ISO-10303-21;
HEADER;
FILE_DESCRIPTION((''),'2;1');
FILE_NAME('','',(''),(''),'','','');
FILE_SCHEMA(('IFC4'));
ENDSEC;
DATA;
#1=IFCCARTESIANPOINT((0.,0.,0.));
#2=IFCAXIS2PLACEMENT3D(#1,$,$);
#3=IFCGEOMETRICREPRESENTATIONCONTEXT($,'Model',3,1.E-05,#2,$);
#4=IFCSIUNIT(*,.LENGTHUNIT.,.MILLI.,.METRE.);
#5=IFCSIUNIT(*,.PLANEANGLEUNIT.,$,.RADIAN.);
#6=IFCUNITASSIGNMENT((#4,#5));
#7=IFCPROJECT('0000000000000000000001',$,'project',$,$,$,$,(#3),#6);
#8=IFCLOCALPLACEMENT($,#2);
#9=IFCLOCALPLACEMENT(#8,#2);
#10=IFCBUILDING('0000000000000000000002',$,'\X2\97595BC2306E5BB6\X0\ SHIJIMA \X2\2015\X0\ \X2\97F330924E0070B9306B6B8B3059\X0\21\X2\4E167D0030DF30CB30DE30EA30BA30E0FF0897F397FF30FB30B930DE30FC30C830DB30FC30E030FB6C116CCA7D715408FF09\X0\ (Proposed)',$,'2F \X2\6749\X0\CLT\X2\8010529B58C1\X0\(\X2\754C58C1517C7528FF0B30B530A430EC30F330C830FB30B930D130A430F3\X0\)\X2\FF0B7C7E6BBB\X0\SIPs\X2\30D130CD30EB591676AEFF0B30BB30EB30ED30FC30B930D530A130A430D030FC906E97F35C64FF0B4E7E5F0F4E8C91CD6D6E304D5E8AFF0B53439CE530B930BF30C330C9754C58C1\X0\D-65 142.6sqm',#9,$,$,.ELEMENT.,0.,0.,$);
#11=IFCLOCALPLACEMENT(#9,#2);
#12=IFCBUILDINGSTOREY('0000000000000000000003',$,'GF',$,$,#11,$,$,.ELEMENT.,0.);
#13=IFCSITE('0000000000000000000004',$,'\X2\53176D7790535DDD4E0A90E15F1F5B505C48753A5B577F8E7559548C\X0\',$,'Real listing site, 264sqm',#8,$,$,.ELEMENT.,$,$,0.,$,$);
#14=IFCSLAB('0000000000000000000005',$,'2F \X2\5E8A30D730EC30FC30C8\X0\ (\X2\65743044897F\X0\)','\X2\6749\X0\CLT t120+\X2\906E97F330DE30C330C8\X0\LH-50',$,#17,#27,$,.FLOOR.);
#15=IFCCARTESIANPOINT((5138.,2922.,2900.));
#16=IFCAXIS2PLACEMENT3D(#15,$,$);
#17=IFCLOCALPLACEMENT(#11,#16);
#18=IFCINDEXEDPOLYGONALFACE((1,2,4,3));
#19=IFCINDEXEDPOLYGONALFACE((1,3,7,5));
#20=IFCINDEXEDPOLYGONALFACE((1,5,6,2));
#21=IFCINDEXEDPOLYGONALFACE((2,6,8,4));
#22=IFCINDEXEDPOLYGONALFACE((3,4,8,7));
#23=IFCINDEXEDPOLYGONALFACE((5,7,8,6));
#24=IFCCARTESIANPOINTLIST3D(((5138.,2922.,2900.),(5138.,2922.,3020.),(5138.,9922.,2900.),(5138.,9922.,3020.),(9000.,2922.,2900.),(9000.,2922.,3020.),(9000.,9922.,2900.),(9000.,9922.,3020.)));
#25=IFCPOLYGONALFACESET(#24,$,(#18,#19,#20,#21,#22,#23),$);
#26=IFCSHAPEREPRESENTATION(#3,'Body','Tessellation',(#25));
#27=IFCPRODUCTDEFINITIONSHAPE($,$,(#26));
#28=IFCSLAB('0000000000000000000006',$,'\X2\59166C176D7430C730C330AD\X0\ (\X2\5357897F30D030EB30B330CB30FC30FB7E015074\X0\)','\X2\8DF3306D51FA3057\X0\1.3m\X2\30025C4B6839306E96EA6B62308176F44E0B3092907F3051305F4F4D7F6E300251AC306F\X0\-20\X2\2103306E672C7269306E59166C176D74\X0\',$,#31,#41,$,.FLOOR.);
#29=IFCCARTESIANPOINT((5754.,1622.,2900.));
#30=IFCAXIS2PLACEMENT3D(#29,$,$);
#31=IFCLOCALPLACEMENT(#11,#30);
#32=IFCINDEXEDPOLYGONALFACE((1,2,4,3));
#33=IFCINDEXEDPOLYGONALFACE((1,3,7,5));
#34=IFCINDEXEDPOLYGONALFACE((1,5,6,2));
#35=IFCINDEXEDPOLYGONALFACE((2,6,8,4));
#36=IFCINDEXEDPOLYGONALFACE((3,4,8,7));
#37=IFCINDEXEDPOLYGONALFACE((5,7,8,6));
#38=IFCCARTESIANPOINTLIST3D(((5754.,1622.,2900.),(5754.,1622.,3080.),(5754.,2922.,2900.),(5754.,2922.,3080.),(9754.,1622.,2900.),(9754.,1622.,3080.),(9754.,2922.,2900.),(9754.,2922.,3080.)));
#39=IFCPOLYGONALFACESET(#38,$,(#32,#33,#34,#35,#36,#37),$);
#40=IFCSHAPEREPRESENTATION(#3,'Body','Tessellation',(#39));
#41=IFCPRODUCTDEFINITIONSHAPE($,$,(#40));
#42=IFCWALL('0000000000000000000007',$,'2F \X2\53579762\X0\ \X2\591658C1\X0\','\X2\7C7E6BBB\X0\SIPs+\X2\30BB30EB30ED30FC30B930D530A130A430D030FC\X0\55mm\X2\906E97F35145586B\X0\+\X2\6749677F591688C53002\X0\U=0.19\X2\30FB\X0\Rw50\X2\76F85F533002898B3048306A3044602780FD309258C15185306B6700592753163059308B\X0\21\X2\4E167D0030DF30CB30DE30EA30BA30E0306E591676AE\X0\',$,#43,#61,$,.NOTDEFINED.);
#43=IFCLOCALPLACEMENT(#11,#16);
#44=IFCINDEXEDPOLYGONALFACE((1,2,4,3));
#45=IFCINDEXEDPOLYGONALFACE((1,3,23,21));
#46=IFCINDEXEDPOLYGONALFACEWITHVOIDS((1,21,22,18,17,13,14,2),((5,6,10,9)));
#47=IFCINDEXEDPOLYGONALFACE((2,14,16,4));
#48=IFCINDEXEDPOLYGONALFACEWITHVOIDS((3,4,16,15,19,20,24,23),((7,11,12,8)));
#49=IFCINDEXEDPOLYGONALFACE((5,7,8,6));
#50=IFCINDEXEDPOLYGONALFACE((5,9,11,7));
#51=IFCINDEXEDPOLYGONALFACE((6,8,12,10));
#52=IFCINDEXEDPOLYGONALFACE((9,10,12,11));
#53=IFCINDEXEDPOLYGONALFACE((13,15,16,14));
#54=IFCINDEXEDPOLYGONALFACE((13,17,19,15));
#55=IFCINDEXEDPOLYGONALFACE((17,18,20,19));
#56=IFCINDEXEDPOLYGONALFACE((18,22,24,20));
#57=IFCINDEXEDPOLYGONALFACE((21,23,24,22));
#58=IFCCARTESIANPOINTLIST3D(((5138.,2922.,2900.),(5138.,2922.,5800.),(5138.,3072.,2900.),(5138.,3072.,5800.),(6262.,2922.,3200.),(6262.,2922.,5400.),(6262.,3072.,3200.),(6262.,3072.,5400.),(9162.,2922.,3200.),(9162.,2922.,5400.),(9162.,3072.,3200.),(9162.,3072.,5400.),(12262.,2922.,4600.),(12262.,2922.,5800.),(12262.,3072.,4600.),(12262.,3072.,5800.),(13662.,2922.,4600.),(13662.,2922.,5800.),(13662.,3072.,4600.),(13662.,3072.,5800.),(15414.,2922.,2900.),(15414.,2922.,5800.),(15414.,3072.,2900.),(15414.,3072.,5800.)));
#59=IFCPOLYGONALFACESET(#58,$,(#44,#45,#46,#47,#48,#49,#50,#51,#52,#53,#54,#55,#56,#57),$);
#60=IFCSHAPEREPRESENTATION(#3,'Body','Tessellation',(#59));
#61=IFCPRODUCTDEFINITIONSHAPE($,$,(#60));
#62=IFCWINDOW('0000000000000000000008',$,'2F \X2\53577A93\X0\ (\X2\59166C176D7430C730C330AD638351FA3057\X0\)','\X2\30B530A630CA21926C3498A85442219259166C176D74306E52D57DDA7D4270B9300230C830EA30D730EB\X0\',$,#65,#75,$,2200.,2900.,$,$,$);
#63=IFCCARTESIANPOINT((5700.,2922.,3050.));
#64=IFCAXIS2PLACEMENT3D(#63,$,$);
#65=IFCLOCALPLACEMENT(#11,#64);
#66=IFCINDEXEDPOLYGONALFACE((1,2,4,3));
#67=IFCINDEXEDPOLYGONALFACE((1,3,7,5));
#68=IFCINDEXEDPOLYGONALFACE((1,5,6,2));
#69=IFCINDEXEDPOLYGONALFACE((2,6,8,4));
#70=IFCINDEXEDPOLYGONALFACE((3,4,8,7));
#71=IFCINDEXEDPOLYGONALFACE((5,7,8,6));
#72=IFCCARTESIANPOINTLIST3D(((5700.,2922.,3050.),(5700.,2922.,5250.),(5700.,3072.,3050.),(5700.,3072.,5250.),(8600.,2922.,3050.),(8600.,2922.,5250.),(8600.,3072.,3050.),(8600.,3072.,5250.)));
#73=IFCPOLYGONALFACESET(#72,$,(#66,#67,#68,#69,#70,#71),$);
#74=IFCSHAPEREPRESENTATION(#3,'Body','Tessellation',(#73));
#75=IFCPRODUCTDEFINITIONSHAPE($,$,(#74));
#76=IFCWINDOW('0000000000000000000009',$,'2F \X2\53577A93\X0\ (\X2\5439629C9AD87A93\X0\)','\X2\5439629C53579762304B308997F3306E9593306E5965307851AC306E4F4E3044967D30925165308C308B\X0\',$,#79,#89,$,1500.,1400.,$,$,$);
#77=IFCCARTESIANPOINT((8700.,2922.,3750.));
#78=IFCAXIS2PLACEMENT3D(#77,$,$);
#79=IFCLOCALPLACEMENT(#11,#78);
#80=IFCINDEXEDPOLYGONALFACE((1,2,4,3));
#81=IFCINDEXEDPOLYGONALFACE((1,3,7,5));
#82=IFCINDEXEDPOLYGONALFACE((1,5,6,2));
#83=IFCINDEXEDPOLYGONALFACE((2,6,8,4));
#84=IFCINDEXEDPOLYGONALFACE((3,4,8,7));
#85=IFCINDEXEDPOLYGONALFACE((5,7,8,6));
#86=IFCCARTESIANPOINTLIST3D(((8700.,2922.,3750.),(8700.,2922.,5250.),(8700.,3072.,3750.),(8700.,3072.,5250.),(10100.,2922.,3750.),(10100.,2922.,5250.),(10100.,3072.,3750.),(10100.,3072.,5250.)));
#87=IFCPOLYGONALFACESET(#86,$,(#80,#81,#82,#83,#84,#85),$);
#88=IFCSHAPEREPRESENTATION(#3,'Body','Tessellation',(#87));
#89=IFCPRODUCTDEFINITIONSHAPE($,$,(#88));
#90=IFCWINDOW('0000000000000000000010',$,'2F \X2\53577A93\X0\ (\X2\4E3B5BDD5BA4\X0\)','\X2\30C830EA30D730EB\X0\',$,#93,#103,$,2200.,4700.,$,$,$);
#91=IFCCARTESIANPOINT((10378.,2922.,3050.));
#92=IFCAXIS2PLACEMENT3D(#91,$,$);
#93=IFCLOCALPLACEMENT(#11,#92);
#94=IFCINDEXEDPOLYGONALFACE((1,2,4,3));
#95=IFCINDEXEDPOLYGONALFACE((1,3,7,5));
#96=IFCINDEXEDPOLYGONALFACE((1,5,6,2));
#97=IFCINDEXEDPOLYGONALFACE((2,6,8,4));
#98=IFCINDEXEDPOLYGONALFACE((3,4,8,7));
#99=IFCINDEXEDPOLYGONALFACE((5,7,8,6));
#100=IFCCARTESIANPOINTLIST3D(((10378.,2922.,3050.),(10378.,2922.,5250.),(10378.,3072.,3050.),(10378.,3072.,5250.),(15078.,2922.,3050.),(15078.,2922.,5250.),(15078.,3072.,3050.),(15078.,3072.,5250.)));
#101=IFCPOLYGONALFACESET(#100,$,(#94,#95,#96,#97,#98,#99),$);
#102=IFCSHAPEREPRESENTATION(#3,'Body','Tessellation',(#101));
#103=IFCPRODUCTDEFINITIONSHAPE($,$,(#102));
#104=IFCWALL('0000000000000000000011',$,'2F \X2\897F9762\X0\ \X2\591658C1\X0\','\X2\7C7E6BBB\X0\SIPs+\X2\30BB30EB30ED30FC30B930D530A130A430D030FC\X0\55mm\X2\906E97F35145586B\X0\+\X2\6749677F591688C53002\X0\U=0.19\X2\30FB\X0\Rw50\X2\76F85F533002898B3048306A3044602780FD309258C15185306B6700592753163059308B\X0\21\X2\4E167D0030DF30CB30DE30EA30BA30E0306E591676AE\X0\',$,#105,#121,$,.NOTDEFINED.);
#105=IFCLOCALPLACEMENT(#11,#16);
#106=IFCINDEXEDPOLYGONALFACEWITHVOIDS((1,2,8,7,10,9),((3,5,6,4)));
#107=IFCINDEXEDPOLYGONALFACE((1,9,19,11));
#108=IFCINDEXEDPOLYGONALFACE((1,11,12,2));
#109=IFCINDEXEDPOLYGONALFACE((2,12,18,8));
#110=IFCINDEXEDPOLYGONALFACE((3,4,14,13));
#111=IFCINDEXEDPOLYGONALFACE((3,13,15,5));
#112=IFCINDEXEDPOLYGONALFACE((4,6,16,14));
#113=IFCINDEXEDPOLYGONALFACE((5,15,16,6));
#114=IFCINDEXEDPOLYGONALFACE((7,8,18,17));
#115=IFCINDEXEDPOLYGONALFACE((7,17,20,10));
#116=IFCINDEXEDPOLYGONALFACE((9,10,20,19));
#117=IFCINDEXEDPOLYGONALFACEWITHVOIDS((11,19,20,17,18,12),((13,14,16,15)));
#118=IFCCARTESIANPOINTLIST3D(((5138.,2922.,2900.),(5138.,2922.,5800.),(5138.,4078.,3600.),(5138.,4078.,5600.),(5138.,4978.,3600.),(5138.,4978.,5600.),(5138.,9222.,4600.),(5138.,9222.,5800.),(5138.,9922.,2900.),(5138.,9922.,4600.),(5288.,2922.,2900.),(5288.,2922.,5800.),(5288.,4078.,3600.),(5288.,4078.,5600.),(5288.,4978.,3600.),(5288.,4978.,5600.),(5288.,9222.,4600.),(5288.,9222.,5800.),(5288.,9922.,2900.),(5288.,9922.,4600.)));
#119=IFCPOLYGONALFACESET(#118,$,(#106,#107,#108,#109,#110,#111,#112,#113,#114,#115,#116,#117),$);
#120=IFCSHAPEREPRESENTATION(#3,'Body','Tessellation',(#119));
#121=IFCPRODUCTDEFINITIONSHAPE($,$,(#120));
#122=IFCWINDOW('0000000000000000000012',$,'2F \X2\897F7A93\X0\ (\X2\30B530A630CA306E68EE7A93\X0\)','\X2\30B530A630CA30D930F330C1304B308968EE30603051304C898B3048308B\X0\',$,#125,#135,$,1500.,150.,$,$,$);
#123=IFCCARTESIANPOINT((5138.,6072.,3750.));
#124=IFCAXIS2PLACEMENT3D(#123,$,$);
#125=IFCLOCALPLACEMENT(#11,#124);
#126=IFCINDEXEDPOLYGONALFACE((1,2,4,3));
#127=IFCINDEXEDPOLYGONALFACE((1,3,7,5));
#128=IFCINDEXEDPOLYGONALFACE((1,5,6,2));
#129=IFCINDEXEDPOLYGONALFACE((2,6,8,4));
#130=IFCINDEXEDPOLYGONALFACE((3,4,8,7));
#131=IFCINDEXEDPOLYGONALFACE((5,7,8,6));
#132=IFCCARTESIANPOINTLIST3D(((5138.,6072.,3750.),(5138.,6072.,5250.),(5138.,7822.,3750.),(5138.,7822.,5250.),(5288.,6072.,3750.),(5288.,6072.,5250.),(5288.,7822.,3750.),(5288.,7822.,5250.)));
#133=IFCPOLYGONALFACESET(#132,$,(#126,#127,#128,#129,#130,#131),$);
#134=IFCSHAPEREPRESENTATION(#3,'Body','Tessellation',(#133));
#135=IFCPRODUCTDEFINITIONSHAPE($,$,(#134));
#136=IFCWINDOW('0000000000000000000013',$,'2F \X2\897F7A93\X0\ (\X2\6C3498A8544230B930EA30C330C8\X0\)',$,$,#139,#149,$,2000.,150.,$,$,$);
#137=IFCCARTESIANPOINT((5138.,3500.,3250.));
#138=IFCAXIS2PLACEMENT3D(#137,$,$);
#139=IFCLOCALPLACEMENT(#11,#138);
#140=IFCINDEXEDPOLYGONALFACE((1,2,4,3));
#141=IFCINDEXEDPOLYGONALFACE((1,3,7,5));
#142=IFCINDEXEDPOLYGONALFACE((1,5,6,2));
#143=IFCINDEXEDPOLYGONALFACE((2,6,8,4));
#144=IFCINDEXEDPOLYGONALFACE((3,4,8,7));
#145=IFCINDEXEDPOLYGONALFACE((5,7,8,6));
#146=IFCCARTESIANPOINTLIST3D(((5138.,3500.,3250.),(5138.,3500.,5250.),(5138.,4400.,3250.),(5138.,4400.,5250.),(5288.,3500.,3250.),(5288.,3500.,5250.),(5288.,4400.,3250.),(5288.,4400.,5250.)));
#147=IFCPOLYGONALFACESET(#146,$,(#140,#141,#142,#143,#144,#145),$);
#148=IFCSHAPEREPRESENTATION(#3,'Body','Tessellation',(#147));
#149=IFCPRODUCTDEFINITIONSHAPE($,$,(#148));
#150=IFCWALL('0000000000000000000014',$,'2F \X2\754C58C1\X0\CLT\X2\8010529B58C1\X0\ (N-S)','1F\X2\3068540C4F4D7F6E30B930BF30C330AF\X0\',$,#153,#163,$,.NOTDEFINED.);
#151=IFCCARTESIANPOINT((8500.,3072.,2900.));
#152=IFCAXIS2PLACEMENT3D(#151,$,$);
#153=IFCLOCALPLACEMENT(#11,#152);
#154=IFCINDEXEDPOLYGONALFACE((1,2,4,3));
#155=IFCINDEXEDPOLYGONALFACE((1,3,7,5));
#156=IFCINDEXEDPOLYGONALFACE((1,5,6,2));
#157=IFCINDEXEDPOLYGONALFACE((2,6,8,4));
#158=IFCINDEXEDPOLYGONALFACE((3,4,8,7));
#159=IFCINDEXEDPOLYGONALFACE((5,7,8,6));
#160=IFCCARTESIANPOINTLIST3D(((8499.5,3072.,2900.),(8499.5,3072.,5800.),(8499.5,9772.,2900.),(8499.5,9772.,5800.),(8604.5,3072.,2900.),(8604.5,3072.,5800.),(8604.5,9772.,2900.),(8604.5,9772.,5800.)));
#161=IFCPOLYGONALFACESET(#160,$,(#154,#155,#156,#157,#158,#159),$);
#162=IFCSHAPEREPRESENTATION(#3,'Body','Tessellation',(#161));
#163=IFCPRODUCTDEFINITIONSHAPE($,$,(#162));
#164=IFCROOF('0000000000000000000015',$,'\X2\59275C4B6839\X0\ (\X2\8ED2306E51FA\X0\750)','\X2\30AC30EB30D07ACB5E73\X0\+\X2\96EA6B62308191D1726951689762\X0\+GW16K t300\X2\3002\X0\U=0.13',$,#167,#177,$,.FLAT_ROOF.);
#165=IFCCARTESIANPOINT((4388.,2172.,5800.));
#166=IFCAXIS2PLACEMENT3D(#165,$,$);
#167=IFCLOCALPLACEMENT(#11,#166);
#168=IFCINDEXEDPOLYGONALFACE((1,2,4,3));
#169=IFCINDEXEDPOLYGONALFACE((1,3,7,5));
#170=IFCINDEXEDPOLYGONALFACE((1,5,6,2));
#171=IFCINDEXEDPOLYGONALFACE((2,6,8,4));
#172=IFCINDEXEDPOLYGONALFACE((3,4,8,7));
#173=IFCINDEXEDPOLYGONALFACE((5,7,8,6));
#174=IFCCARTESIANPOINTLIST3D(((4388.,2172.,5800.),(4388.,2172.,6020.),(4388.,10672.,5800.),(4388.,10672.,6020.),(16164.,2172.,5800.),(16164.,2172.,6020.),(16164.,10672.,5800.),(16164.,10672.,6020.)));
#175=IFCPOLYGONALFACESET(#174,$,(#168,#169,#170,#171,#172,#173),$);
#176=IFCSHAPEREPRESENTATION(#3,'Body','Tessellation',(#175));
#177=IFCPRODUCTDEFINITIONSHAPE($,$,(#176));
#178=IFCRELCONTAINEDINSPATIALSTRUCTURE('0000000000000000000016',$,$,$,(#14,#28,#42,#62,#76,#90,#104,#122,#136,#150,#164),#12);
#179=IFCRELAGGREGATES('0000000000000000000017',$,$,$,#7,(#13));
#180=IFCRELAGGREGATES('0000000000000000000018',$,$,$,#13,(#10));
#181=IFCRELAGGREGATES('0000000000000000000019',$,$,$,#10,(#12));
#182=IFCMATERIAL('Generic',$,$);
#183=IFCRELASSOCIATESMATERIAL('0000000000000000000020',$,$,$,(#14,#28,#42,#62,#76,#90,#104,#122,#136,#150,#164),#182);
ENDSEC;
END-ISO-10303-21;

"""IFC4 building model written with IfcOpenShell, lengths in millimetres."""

from ifc_helpers import new_model, si_unit, frame, frame_2d, origin, place, context, project, spatial, rectangle, extrude, material, element, fill, save


model = new_model("IFC4")

# Units and contexts
model_context = context("Model", 3, precision=1e-05, world=origin())
ifc_project = project(units=[si_unit("LENGTHUNIT", "METRE", prefix="MILLI"), si_unit("PLANEANGLEUNIT", "RADIAN")], contexts=[model_context])

# Site, building, storey
site_placement = place(None, origin())
site = spatial("IfcSite", under=ifc_project, at=site_placement, Name="北海道川上郡弟子屈町字美留和", ObjectType="Real listing site, 264sqm", CompositionType="ELEMENT", RefElevation=0.0)
building_placement = place(site_placement, origin())
building = spatial("IfcBuilding", under=site, at=building_placement, Name="静寂の家 SHIJIMA ― 音を一点に残す21世紀ミニマリズム（音響・スマートホーム・民泊統合） (Proposed)", ObjectType="2F 杉CLT耐力壁(界壁兼用＋サイレント・スパイン)＋籾殻SIPsパネル外皮＋セルロースファイバー遮音層＋乾式二重浮き床＋千鳥スタッド界壁D-65 142.6sqm", CompositionType="ELEMENT", ElevationOfRefHeight=0.0, ElevationOfTerrain=0.0)
storey_placement = place(building_placement, origin())
storey = spatial("IfcBuildingStorey", under=building, at=storey_placement, Name="GF", CompositionType="ELEMENT", Elevation=0.0)

# Slabs
ifc_material = material(Name="Generic")
slab_1_placement = place(storey_placement, frame((5138.0, 2922.0, 2900.0)))
element("IfcSlab", 1, at=slab_1_placement, inside=storey, material=ifc_material, Name="2F 床プレート (整い西)", Description="杉CLT t120+遮音マットLH-50", PredefinedType="FLOOR", context=model_context, shape_type="SweptSolid", body=[
    extrude(rectangle(XDim=3862.0, YDim=7000.0, at=frame_2d((1931.0, 3500.0))), frame((5138.0, 2922.0, 2900.0)), (0.0, 0.0, 1.0), 120.0),
])
slab_2_placement = place(storey_placement, frame((5754.0, 1622.0, 2900.0)))
element("IfcSlab", 2, at=slab_2_placement, inside=storey, material=ifc_material, Name="外気浴デッキ (南西バルコニー・縁側)", Description="跳ね出し1.3m。屋根の雪止め直下を避けた位置。冬は-20℃の本物の外気浴", PredefinedType="FLOOR", context=model_context, shape_type="SweptSolid", body=[
    extrude(rectangle(XDim=4000.0, YDim=1300.0, at=frame_2d((2000.0, 650.0))), frame((5754.0, 1622.0, 2900.0)), (0.0, 0.0, 1.0), 180.0),
])

# Walls, openings, windows
wall_1_placement = place(storey_placement, frame((5138.0, 2922.0, 2900.0)))
wall_1 = element("IfcWall", 3, at=wall_1_placement, inside=storey, material=ifc_material, Name="2F 南面 外壁", Description="籾殻SIPs+セルロースファイバー55mm遮音充填+杉板外装。U=0.19・Rw50相当。見えない性能を壁内に最大化する21世紀ミニマリズムの外皮", PredefinedType="NOTDEFINED", context=model_context, shape_type="SweptSolid", body=[
    extrude(rectangle(XDim=10276.0, YDim=150.0, at=frame_2d((5138.0, 75.0))), frame((5138.0, 2922.0, 2900.0)), (0.0, 0.0, 1.0), 2900.0),
])
opening_1_placement = place(storey_placement, frame((5700.0, 2922.0, 3050.0)))
opening_1 = element("IfcOpeningElement", 4, at=opening_1_placement, cuts=wall_1, PredefinedType="NOTDEFINED", context=model_context, shape_type="SweptSolid", body=[
    extrude(rectangle(XDim=2900.0, YDim=150.0, at=frame_2d((1450.0, 75.0))), frame((5700.0, 2922.0, 3050.0)), (0.0, 0.0, 1.0), 2200.0),
])
opening_2_placement = place(storey_placement, frame((8700.0, 2922.0, 3750.0)))
opening_2 = element("IfcOpeningElement", 5, at=opening_2_placement, cuts=wall_1, PredefinedType="NOTDEFINED", context=model_context, shape_type="SweptSolid", body=[
    extrude(rectangle(XDim=1400.0, YDim=150.0, at=frame_2d((700.0, 75.0))), frame((8700.0, 2922.0, 3750.0)), (0.0, 0.0, 1.0), 1500.0),
])
opening_3_placement = place(storey_placement, frame((10378.0, 2922.0, 3050.0)))
opening_3 = element("IfcOpeningElement", 6, at=opening_3_placement, cuts=wall_1, PredefinedType="NOTDEFINED", context=model_context, shape_type="SweptSolid", body=[
    extrude(rectangle(XDim=4700.0, YDim=150.0, at=frame_2d((2350.0, 75.0))), frame((10378.0, 2922.0, 3050.0)), (0.0, 0.0, 1.0), 2200.0),
])
window_1_placement = place(storey_placement, frame((5700.0, 2922.0, 3050.0)))
window_1 = element("IfcWindow", 7, at=window_1_placement, inside=storey, material=ifc_material, Name="2F 南窓 (外気浴デッキ掃出し)", Description="サウナ→水風呂→外気浴の動線終点。トリプル", OverallHeight=2200.0, OverallWidth=2900.0, context=model_context, shape_type="SweptSolid", body=[
    extrude(rectangle(XDim=2900.0, YDim=150.0, at=frame_2d((1450.0, 75.0))), frame((5700.0, 2922.0, 3050.0)), (0.0, 0.0, 1.0), 2200.0),
])
fill(opening_1, window_1)
window_2_placement = place(storey_placement, frame((8700.0, 2922.0, 3750.0)))
window_2 = element("IfcWindow", 8, at=window_2_placement, inside=storey, material=ifc_material, Name="2F 南窓 (吹抜高窓)", Description="吹抜南面から音の間の奥へ冬の低い陽を入れる", OverallHeight=1500.0, OverallWidth=1400.0, context=model_context, shape_type="SweptSolid", body=[
    extrude(rectangle(XDim=1400.0, YDim=150.0, at=frame_2d((700.0, 75.0))), frame((8700.0, 2922.0, 3750.0)), (0.0, 0.0, 1.0), 1500.0),
])
fill(opening_2, window_2)
window_3_placement = place(storey_placement, frame((10378.0, 2922.0, 3050.0)))
window_3 = element("IfcWindow", 9, at=window_3_placement, inside=storey, material=ifc_material, Name="2F 南窓 (主寝室)", Description="トリプル", OverallHeight=2200.0, OverallWidth=4700.0, context=model_context, shape_type="SweptSolid", body=[
    extrude(rectangle(XDim=4700.0, YDim=150.0, at=frame_2d((2350.0, 75.0))), frame((10378.0, 2922.0, 3050.0)), (0.0, 0.0, 1.0), 2200.0),
])
fill(opening_3, window_3)
wall_2_placement = place(storey_placement, frame((5138.0, 2922.0, 2900.0)))
wall_2 = element("IfcWall", 10, at=wall_2_placement, inside=storey, material=ifc_material, Name="2F 西面 外壁", Description="籾殻SIPs+セルロースファイバー55mm遮音充填+杉板外装。U=0.19・Rw50相当。見えない性能を壁内に最大化する21世紀ミニマリズムの外皮", PredefinedType="NOTDEFINED", context=model_context, shape_type="SweptSolid", body=[
    extrude(rectangle(XDim=150.0, YDim=7000.0, at=frame_2d((75.0, 3500.0))), frame((5138.0, 2922.0, 2900.0)), (0.0, 0.0, 1.0), 2900.0),
])
opening_4_placement = place(storey_placement, frame((5138.0, 6072.0, 3750.0)))
opening_4 = element("IfcOpeningElement", 11, at=opening_4_placement, cuts=wall_2, PredefinedType="NOTDEFINED", context=model_context, shape_type="SweptSolid", body=[
    extrude(rectangle(XDim=150.0, YDim=1750.0, at=frame_2d((75.0, 875.0))), frame((5138.0, 6072.0, 3750.0)), (0.0, 0.0, 1.0), 1500.0),
])
opening_5_placement = place(storey_placement, frame((5138.0, 3500.0, 3250.0)))
opening_5 = element("IfcOpeningElement", 12, at=opening_5_placement, cuts=wall_2, PredefinedType="NOTDEFINED", context=model_context, shape_type="SweptSolid", body=[
    extrude(rectangle(XDim=150.0, YDim=900.0, at=frame_2d((75.0, 450.0))), frame((5138.0, 3500.0, 3250.0)), (0.0, 0.0, 1.0), 2000.0),
])
window_4_placement = place(storey_placement, frame((5138.0, 6072.0, 3750.0)))
window_4 = element("IfcWindow", 13, at=window_4_placement, inside=storey, material=ifc_material, Name="2F 西窓 (サウナの森窓)", Description="サウナベンチから森だけが見える", OverallHeight=1500.0, OverallWidth=150.0, context=model_context, shape_type="SweptSolid", body=[
    extrude(rectangle(XDim=150.0, YDim=1750.0, at=frame_2d((75.0, 875.0))), frame((5138.0, 6072.0, 3750.0)), (0.0, 0.0, 1.0), 1500.0),
])
fill(opening_4, window_4)
window_5_placement = place(storey_placement, frame((5138.0, 3500.0, 3250.0)))
window_5 = element("IfcWindow", 14, at=window_5_placement, inside=storey, material=ifc_material, Name="2F 西窓 (水風呂スリット)", OverallHeight=2000.0, OverallWidth=150.0, context=model_context, shape_type="SweptSolid", body=[
    extrude(rectangle(XDim=150.0, YDim=900.0, at=frame_2d((75.0, 450.0))), frame((5138.0, 3500.0, 3250.0)), (0.0, 0.0, 1.0), 2000.0),
])
fill(opening_5, window_5)

# Wall
wall_3_placement = place(storey_placement, frame((8500.0, 3072.0, 2900.0)))
element("IfcWall", 15, at=wall_3_placement, inside=storey, material=ifc_material, Name="2F 界壁CLT耐力壁 (N-S)", Description="1Fと同位置スタック", PredefinedType="NOTDEFINED", context=model_context, shape_type="SweptSolid", body=[
    extrude(rectangle(XDim=105.0, YDim=6700.0, at=frame_2d((52.0, 3350.0))), frame((8500.0, 3072.0, 2900.0)), (0.0, 0.0, 1.0), 2900.0),
])

# Roof
roof_placement = place(storey_placement, frame((4388.0, 2172.0, 5800.0)))
element("IfcRoof", 16, at=roof_placement, inside=storey, material=ifc_material, Name="大屋根 (軒の出750)", Description="ガルバ立平+雪止め金物全面+GW16K t300。U=0.13", PredefinedType="FLAT_ROOF", context=model_context, shape_type="SweptSolid", body=[
    extrude(rectangle(XDim=11776.0, YDim=8500.0, at=frame_2d((5888.0, 4250.0))), frame((4388.0, 2172.0, 5800.0)), (0.0, 0.0, 1.0), 220.0),
])

save(model, "model.ifc")
